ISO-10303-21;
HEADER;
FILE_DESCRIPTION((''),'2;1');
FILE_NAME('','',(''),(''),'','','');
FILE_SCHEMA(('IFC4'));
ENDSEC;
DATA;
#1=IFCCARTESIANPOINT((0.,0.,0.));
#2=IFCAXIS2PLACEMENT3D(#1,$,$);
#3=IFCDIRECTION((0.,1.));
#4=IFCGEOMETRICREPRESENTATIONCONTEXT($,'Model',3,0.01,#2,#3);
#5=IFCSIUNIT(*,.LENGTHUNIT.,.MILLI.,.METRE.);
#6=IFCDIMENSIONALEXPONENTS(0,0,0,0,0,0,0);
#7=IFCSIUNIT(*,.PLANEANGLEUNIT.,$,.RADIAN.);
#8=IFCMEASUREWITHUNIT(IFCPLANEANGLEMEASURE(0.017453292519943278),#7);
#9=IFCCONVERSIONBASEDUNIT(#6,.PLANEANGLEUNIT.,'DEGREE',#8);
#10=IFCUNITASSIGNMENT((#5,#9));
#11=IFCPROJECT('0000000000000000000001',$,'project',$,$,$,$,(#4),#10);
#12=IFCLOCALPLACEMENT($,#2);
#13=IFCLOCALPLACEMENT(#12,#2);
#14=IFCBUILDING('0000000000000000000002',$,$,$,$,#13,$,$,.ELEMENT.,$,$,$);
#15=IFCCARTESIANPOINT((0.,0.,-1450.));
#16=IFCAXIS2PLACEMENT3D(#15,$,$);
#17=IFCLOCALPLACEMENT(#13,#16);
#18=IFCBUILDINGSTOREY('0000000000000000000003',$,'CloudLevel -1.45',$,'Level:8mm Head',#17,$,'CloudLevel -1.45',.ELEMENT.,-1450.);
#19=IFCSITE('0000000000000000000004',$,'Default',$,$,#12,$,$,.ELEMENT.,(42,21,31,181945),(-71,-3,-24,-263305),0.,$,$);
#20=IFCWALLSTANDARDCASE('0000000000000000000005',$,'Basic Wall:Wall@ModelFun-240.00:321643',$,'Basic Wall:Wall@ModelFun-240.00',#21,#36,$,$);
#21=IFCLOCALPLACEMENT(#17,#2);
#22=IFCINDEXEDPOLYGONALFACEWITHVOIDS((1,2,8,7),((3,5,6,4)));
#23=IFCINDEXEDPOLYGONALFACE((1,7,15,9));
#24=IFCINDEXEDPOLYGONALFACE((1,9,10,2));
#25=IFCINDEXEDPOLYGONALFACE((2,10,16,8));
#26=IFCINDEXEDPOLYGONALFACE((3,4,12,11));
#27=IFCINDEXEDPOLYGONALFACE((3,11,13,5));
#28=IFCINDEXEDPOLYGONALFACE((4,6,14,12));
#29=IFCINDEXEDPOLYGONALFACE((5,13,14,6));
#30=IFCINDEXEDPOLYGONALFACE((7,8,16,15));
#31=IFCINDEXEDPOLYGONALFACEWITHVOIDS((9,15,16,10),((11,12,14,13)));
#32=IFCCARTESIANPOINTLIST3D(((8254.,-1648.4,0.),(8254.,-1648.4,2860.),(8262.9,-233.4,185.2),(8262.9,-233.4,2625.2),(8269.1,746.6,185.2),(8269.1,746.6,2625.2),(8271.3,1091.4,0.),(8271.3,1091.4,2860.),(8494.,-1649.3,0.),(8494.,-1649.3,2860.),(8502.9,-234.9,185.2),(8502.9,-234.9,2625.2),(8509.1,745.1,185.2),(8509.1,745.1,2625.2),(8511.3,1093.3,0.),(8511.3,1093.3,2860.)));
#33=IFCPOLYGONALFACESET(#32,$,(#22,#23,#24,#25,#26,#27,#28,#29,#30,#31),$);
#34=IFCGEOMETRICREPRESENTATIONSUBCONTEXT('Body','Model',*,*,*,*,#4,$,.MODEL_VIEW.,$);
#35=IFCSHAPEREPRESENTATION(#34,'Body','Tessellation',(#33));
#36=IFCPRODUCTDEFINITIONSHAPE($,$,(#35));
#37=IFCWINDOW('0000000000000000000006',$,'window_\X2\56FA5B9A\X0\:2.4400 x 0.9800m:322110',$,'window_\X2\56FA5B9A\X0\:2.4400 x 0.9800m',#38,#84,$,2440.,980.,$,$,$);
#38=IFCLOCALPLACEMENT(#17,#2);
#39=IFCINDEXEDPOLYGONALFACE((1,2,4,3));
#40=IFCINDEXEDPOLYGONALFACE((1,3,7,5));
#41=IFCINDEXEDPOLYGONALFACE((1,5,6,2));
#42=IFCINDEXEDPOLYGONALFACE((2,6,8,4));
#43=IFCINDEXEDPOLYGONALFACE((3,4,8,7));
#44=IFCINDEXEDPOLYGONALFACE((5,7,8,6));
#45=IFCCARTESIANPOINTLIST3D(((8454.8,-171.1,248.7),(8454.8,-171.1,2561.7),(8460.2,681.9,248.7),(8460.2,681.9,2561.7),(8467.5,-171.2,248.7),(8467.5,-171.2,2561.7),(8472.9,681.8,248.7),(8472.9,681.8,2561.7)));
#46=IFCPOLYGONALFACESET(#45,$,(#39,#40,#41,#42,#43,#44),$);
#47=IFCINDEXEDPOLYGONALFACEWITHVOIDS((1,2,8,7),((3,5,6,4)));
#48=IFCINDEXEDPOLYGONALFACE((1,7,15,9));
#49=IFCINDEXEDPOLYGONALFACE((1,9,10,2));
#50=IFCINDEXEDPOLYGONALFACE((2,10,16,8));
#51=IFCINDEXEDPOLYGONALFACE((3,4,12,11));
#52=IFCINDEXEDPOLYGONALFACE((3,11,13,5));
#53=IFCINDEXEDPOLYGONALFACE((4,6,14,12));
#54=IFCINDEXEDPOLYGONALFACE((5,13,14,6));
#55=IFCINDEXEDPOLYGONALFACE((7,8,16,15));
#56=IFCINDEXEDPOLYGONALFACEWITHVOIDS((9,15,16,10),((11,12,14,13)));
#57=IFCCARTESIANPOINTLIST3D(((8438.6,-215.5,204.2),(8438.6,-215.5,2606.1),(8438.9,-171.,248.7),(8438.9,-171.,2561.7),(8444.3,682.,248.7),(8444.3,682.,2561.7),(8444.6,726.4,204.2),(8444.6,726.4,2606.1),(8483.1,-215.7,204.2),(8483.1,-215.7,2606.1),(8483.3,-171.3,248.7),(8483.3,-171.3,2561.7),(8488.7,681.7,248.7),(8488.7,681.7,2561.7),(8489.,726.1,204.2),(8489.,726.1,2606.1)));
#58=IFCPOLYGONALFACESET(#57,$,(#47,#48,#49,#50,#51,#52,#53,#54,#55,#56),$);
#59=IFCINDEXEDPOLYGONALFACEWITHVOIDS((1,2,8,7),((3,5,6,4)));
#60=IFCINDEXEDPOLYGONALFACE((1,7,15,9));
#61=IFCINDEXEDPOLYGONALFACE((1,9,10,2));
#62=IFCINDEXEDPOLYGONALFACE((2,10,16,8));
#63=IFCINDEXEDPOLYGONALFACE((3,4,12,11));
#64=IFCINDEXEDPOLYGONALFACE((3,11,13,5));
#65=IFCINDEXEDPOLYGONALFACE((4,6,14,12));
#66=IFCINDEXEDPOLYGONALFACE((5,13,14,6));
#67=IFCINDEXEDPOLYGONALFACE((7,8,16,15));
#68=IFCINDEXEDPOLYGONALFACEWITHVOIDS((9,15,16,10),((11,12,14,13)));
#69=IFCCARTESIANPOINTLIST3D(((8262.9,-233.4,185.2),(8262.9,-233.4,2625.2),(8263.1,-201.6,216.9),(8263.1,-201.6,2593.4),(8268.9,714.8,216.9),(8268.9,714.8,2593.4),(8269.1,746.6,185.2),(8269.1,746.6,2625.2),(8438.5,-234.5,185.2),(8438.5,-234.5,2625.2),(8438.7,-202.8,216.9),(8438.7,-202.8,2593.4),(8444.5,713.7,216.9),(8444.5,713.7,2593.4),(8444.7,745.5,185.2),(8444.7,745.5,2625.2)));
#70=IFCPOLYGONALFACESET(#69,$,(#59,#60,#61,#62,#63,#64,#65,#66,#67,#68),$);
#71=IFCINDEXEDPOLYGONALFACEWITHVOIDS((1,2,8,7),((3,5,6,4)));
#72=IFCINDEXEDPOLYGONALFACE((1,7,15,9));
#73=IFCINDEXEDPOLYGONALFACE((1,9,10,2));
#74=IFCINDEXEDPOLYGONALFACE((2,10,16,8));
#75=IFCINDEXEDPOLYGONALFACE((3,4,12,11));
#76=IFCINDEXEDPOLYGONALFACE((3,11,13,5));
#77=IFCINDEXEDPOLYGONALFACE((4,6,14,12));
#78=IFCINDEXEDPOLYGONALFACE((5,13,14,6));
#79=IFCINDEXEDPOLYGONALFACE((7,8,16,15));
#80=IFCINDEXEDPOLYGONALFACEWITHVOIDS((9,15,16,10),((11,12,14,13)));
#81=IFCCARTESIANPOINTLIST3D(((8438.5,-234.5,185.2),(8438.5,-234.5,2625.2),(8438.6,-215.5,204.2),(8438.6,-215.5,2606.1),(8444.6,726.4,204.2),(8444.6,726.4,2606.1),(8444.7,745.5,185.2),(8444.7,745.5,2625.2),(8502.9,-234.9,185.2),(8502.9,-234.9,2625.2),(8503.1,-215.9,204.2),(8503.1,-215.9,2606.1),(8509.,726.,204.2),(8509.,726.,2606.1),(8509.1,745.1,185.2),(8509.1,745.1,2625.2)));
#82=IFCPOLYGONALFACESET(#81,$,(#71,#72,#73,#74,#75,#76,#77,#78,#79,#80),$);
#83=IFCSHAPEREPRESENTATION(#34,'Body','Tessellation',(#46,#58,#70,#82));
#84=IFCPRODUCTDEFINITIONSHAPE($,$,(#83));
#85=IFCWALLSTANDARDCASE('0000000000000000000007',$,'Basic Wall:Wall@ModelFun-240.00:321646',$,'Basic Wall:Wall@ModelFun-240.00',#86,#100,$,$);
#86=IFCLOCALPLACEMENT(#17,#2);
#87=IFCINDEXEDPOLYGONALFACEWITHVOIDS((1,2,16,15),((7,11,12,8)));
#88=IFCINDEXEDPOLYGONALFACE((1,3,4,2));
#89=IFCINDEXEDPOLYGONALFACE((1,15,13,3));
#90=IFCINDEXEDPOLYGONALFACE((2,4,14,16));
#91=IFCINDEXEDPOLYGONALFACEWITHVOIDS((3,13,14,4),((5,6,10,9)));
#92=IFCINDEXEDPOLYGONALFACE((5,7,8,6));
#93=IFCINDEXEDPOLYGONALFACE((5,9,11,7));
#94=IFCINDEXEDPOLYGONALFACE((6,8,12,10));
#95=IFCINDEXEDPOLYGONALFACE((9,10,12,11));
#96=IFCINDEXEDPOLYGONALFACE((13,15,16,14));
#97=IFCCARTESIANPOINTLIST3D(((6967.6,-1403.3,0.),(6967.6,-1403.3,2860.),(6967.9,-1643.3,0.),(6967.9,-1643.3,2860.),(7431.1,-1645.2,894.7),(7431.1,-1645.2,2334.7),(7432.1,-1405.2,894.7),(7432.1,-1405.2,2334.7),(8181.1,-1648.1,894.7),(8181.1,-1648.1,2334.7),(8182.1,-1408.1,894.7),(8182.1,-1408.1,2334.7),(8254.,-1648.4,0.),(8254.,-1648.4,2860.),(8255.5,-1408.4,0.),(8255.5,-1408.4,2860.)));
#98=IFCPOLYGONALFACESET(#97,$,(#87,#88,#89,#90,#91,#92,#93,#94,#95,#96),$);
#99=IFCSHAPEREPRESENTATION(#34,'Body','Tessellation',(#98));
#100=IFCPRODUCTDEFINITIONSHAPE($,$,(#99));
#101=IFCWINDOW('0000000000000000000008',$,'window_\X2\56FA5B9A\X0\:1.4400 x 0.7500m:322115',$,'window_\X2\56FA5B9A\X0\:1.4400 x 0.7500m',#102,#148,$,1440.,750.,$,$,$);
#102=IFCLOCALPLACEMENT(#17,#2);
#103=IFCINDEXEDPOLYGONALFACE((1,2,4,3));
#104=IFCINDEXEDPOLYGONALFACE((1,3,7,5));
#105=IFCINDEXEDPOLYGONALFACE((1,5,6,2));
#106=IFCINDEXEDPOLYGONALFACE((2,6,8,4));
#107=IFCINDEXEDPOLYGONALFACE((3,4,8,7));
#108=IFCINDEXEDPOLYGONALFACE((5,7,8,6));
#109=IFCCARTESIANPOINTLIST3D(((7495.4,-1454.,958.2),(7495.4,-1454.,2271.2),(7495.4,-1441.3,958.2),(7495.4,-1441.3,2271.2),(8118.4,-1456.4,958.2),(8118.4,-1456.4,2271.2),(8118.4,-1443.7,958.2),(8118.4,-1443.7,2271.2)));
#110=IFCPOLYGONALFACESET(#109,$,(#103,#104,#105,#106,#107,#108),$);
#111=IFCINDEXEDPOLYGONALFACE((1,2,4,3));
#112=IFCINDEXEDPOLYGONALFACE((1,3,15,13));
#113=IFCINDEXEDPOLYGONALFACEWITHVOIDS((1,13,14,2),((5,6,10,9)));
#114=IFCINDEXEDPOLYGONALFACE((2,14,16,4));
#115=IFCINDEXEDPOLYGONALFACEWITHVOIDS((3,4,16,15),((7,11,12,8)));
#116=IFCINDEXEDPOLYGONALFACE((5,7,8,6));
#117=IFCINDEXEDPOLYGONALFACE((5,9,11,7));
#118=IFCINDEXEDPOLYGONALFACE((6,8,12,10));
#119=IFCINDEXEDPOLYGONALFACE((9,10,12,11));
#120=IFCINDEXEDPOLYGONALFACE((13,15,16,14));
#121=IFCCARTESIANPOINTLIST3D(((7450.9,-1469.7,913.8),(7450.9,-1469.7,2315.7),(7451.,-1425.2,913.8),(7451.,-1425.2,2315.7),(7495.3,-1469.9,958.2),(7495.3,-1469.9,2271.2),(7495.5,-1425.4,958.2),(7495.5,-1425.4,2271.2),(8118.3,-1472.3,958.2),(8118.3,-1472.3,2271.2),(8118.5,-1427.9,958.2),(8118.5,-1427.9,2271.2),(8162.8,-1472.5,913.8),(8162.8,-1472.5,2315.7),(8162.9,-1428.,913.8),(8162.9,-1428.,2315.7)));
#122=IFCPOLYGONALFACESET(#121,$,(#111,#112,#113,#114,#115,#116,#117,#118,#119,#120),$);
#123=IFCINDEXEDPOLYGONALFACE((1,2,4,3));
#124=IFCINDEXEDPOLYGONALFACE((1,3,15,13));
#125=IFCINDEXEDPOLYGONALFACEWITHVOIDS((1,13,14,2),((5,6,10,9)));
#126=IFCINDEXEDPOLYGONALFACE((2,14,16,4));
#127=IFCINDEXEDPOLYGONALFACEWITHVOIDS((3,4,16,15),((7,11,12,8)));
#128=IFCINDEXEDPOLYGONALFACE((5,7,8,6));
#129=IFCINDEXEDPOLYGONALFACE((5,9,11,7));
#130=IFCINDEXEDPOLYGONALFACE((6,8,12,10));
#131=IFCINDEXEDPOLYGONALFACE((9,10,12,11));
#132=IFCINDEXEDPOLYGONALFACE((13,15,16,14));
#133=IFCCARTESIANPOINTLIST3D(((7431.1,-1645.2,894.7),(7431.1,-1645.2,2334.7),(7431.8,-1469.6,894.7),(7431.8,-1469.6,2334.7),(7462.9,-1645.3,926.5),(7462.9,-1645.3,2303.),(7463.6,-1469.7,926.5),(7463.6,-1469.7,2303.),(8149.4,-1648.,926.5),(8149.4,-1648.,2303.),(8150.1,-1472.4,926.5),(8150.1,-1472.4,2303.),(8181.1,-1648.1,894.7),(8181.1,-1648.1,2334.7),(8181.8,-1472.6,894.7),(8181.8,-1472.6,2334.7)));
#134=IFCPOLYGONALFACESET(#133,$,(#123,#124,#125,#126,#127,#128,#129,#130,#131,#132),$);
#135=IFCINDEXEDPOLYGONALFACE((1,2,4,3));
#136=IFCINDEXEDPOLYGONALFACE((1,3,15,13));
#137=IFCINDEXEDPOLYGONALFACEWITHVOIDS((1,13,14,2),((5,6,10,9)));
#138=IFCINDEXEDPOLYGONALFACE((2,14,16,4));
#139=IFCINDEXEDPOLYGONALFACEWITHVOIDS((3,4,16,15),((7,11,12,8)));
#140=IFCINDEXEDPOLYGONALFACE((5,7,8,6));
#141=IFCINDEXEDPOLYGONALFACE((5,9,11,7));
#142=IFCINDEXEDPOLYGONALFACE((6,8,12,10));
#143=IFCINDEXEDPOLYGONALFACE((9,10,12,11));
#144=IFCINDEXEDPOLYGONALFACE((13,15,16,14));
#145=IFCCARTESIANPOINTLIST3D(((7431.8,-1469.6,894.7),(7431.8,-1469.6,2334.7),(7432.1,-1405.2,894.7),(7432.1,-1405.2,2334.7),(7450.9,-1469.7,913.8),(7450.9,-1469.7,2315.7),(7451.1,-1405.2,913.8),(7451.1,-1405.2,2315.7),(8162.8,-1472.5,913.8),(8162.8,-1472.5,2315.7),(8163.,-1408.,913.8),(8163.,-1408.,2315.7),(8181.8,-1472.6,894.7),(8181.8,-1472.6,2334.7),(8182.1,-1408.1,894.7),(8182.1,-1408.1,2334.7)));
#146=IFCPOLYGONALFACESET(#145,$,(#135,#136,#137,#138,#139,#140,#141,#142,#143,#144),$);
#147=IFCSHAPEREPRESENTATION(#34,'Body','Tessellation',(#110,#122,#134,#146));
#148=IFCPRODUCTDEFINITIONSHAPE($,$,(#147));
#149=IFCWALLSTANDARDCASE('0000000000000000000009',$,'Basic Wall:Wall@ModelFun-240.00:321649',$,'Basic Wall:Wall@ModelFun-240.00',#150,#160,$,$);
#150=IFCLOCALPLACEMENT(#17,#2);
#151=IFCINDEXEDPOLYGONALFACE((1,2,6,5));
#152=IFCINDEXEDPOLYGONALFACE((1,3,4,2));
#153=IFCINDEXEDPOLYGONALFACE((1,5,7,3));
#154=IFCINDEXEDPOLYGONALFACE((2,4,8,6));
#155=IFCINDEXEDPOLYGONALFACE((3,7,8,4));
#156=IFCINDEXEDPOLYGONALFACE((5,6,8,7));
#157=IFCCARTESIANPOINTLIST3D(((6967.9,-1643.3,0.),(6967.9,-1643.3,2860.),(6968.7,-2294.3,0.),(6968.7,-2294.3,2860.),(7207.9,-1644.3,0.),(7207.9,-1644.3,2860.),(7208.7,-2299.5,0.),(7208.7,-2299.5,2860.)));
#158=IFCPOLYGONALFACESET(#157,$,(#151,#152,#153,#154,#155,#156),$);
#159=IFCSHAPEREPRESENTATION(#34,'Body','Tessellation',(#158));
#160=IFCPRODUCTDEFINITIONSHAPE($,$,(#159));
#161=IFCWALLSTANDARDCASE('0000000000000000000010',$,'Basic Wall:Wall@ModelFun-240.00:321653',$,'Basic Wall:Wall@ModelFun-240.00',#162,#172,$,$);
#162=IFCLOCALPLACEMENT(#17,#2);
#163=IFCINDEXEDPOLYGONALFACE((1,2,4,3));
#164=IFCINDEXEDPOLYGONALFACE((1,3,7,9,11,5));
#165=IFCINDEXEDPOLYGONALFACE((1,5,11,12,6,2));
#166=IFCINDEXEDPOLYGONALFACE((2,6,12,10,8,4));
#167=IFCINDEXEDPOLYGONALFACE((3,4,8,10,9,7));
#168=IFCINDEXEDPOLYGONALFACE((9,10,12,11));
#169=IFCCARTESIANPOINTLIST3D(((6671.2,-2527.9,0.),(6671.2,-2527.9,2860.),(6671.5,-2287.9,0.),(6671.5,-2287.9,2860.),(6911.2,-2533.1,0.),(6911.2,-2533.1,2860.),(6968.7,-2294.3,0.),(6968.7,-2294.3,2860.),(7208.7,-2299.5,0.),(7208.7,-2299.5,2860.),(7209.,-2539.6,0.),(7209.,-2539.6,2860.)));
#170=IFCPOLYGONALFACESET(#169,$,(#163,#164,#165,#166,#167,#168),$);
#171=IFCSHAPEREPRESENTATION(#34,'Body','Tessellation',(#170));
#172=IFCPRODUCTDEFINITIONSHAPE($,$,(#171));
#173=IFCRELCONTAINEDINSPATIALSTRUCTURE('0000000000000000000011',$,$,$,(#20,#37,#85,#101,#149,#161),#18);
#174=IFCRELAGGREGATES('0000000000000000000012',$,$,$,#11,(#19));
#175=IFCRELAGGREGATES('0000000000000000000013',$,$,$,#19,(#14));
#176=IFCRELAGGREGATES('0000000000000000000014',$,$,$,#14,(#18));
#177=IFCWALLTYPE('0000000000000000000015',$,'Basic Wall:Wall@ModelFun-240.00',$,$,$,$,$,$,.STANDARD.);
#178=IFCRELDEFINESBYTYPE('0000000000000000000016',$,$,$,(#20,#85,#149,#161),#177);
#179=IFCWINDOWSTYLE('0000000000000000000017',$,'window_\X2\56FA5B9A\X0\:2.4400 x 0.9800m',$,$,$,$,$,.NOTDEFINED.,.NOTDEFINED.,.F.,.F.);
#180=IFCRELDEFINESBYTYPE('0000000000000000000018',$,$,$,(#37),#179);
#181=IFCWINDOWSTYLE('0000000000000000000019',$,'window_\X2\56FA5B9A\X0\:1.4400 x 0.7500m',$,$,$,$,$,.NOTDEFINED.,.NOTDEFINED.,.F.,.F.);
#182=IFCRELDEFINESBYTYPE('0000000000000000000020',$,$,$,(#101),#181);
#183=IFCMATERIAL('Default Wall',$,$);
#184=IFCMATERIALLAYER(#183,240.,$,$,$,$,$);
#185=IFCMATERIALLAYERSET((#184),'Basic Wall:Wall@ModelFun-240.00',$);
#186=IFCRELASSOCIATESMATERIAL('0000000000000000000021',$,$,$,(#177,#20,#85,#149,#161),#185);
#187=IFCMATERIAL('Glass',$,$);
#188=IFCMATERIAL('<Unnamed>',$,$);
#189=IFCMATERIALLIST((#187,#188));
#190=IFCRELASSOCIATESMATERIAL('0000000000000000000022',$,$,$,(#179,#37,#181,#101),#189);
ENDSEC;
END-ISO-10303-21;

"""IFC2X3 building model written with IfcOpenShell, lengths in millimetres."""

from ifc_helpers import new_model, entity, si_unit, converted_unit, direction, frame, frame_2d, origin, place, context, subcontext, project, spatial, polyline, rectangle, outline, extrude, source, transform, mapped, material, material_list, layer, layer_set, layer_usage, type_object, type_shapes, element, fill, save


model = new_model("IFC2X3")

# Units and contexts
model_context = context("Model", 3, precision=0.01, world=origin(), true_north=direction((0.0, 1.0)))
body_context = subcontext(model_context, "Body", "Model", "MODEL_VIEW")
ifc_project = project(units=[si_unit("LENGTHUNIT", "METRE", prefix="MILLI"), converted_unit("PLANEANGLEUNIT", "DEGREE", entity("IfcPlaneAngleMeasure", 0.017453292519943278), si_unit("PLANEANGLEUNIT", "RADIAN"), dimensions=[0, 0, 0, 0, 0, 0, 0])], contexts=[model_context])

# Site, building, storey
site_placement = place(None, origin())
site = spatial("IfcSite", under=ifc_project, at=site_placement, Name="Default", CompositionType="ELEMENT", RefLatitude=(42, 21, 31, 181945), RefLongitude=(-71, -3, -24, -263305), RefElevation=0.0)
building_placement = place(site_placement, origin())
building = spatial("IfcBuilding", under=site, at=building_placement, CompositionType="ELEMENT")
storey_placement = place(building_placement, frame((0.0, 0.0, -1450.0)))
storey = spatial("IfcBuildingStorey", under=building, at=storey_placement, Name="CloudLevel -1.45", ObjectType="Level:8mm Head", LongName="CloudLevel -1.45", CompositionType="ELEMENT", Elevation=-1450.0)

# Walls, openings, windows
ifc_material_1 = material(Name="Default Wall")
ifc_layer_1 = layer(ifc_material_1, 240.0)
ifc_layer_set_1 = layer_set([ifc_layer_1], Name="Basic Wall:Wall@ModelFun-240.00")
ifc_layer_usage_1 = layer_usage(ifc_layer_set_1, "AXIS2", "NEGATIVE", 120.0)
wall_type_1 = type_object("IfcWallType", Name="Basic Wall:Wall@ModelFun-240.00", PredefinedType="STANDARD", material=ifc_layer_set_1)
wall_1_placement = place(storey_placement, frame((8374.0, -1649.1, 0.0), z_axis=(0.0, 0.0, 1.0), x_axis=(0.006325, 0.99998, 0.0)))
wall_1 = element("IfcWallStandardCase", 1, at=wall_1_placement, inside=storey, type_object=wall_type_1, material=ifc_layer_usage_1, Name="Basic Wall:Wall@ModelFun-240.00:321643", ObjectType="Basic Wall:Wall@ModelFun-240.00", context=body_context, shape_type="SweptSolid", body=[
    extrude(outline(polyline([(2743.3, -120.0), (2739.9, 120.0), (240.0, 120.0), (0.0, 120.0), (0.3, -16.2), (0.6, -120.0), (240.6, -120.0), (2743.3, -120.0)])), origin(), (0.0, 0.0, 1.0), 2860.0),
])
opening_1_placement = place(wall_1_placement, frame((2395.0, 120.0, 185.2)))
opening_1 = element("IfcOpeningElement", 2, at=opening_1_placement, cuts=wall_1, ObjectType="Opening", context=body_context, shape_type="SweptSolid", body=[
    extrude(rectangle(XDim=2440.0, YDim=980.0, at=frame_2d((1220.0, 490.0), x_axis=(-1.0, 0.0))), frame((0.0, 0.0, 0.0), z_axis=(0.0, -1.0, 0.0), x_axis=(0.0, 0.0, 1.0)), (0.0, 0.0, 1.0), 240.0),
])
ifc_material_2 = material(Name="Glass")
ifc_material_3 = material(Name="<Unnamed>")
ifc_material_list = material_list([ifc_material_2, ifc_material_3])
window_style_1 = type_object("IfcWindowStyle", Name="window_固定:2.4400 x 0.9800m", ConstructionType="NOTDEFINED", OperationType="NOTDEFINED", ParameterTakesPrecedence=False, Sizeable=False, material=ifc_material_list)
shared_shape_1 = source(origin(), body_context, "Body", "SweptSolid", [
    extrude(rectangle(XDim=853.0, YDim=12.7, at=frame_2d((0.0, 0.0), x_axis=(1.0, 0.0))), frame((566.2, 197.8, 63.5)), (0.0, 0.0, 1.0), 2313.0),
    extrude(outline(polyline([(-470.9, -1200.9), (470.9, -1200.9), (470.9, 1200.9), (-470.9, 1200.9), (-470.9, -1200.9)]), holes=[polyline([(-426.5, -1156.5), (-426.5, 1156.5), (426.5, 1156.5), (426.5, -1156.5), (-426.5, -1156.5)])]), frame((566.2, 220.0, 1220.0), z_axis=(0.0, -1.0, 0.0), x_axis=(-1.0, 0.0, 0.0)), (0.0, 0.0, 1.0), 44.4),
    extrude(outline(polyline([(-490.0, -1220.0), (490.0, -1220.0), (490.0, 1220.0), (-490.0, 1220.0), (-490.0, -1220.0)]), holes=[polyline([(-458.2, -1188.2), (-458.2, 1188.2), (458.2, 1188.2), (458.2, -1188.2), (-458.2, -1188.2)])]), frame((566.2, 175.5, 1220.0), z_axis=(0.0, -1.0, 0.0), x_axis=(-1.0, 0.0, 0.0)), (0.0, 0.0, 1.0), 175.5),
    extrude(outline(polyline([(-1220.0, -490.0), (1220.0, -490.0), (1220.0, 490.0), (-1220.0, 490.0), (-1220.0, -490.0)]), holes=[polyline([(-1200.9, -470.9), (-1200.9, 470.9), (1200.9, 470.9), (1200.9, -470.9), (-1200.9, -470.9)])]), frame((566.2, 240.0, 1220.0), z_axis=(0.0, -1.0, 0.0), x_axis=(0.0, 0.0, -1.0)), (0.0, 0.0, 1.0), 64.4),
])
type_shapes(window_style_1, [shared_shape_1])
window_1_placement = place(opening_1_placement, frame((76.2, 0.0, 0.0), z_axis=(0.0, 0.0, 1.0), x_axis=(-1.0, 0.0, 0.0)))
window_1 = element("IfcWindow", 3, at=window_1_placement, inside=storey, type_object=window_style_1, material=ifc_material_list, Name="window_固定:2.4400 x 0.9800m:322110", ObjectType="window_固定:2.4400 x 0.9800m", OverallHeight=2440.0, OverallWidth=980.0, context=body_context, shape_type="MappedRepresentation", body=[
    mapped(shared_shape_1, transform((0.0, 0.0, 0.0), scale=1.0)),
])
fill(opening_1, window_1)
wall_2_placement = place(storey_placement, frame((8255.0, -1528.4, 0.0), z_axis=(0.0, 0.0, 1.0), x_axis=(-0.999992, 0.003928, 0.0)))
wall_2 = element("IfcWallStandardCase", 4, at=wall_2_placement, inside=storey, type_object=wall_type_1, material=ifc_layer_usage_1, Name="Basic Wall:Wall@ModelFun-240.00:321646", ObjectType="Basic Wall:Wall@ModelFun-240.00", context=body_context, shape_type="SweptSolid", body=[
    extrude(outline(polyline([(1287.9, -120.0), (1287.7, -82.7), (1286.7, 117.3), (1286.7, 120.0), (1046.7, 120.0), (0.6, 120.0), (0.0, -120.0), (988.3, -120.0), (1198.3, -120.0), (1287.9, -120.0)])), origin(), (0.0, 0.0, 1.0), 2860.0),
])
opening_2_placement = place(wall_2_placement, frame((823.4, 120.0, 894.7)))
opening_2 = element("IfcOpeningElement", 5, at=opening_2_placement, cuts=wall_2, ObjectType="Opening", context=body_context, shape_type="SweptSolid", body=[
    extrude(rectangle(XDim=1440.0, YDim=750.0, at=frame_2d((720.0, 375.0), x_axis=(-1.0, 0.0))), frame((0.0, 0.0, 0.0), z_axis=(0.0, -1.0, 0.0), x_axis=(0.0, 0.0, 1.0)), (0.0, 0.0, 1.0), 240.0),
])
window_style_2 = type_object("IfcWindowStyle", Name="window_固定:1.4400 x 0.7500m", ConstructionType="NOTDEFINED", OperationType="NOTDEFINED", ParameterTakesPrecedence=False, Sizeable=False, material=ifc_material_list)
shared_shape_2 = source(origin(), body_context, "Body", "SweptSolid", [
    extrude(rectangle(XDim=623.0, YDim=12.7, at=frame_2d((0.0, 0.0), x_axis=(1.0, 0.0))), frame((451.2, 197.8, 63.5)), (0.0, 0.0, 1.0), 1313.0),
    extrude(outline(polyline([(-355.9, -700.9), (355.9, -700.9), (355.9, 700.9), (-355.9, 700.9), (-355.9, -700.9)]), holes=[polyline([(-311.5, -656.5), (-311.5, 656.5), (311.5, 656.5), (311.5, -656.5), (-311.5, -656.5)])]), frame((451.2, 220.0, 720.0), z_axis=(0.0, -1.0, 0.0), x_axis=(-1.0, 0.0, 0.0)), (0.0, 0.0, 1.0), 44.4),
    extrude(outline(polyline([(-375.0, -720.0), (375.0, -720.0), (375.0, 720.0), (-375.0, 720.0), (-375.0, -720.0)]), holes=[polyline([(-343.2, -688.2), (-343.2, 688.2), (343.2, 688.2), (343.2, -688.2), (-343.2, -688.2)])]), frame((451.2, 175.5, 720.0), z_axis=(0.0, -1.0, 0.0), x_axis=(-1.0, 0.0, 0.0)), (0.0, 0.0, 1.0), 175.5),
    extrude(outline(polyline([(-720.0, -375.0), (720.0, -375.0), (720.0, 375.0), (-720.0, 375.0), (-720.0, -375.0)]), holes=[polyline([(-700.9, -355.9), (-700.9, 355.9), (700.9, 355.9), (700.9, -355.9), (-700.9, -355.9)])]), frame((451.2, 240.0, 720.0), z_axis=(0.0, -1.0, 0.0), x_axis=(0.0, 0.0, -1.0)), (0.0, 0.0, 1.0), 64.4),
])
type_shapes(window_style_2, [shared_shape_2])
window_2_placement = place(opening_2_placement, frame((76.2, 0.0, 0.0), z_axis=(0.0, 0.0, 1.0), x_axis=(-1.0, 0.0, 0.0)))
window_2 = element("IfcWindow", 6, at=window_2_placement, inside=storey, type_object=window_style_2, material=ifc_material_list, Name="window_固定:1.4400 x 0.7500m:322115", ObjectType="window_固定:1.4400 x 0.7500m", OverallHeight=1440.0, OverallWidth=750.0, context=body_context, shape_type="MappedRepresentation", body=[
    mapped(shared_shape_2, transform((0.0, 0.0, 0.0), scale=1.0)),
])
fill(opening_2, window_2)

# Walls
wall_3_placement = place(storey_placement, frame((7087.9, -1643.2, 0.0), z_axis=(0.0, 0.0, 1.0), x_axis=(0.001211, -0.999999, 0.0)))
element("IfcWallStandardCase", 7, at=wall_3_placement, inside=storey, type_object=wall_type_1, material=ifc_layer_usage_1, Name="Basic Wall:Wall@ModelFun-240.00:321649", ObjectType="Basic Wall:Wall@ModelFun-240.00", context=body_context, shape_type="SweptSolid", body=[
    extrude(outline(polyline([(651.0, -120.0), (656.5, 120.0), (1.2, 120.0), (0.0, -120.0), (651.0, -120.0)])), origin(), (0.0, 0.0, 1.0), 2860.0),
])
wall_4_placement = place(storey_placement, frame((7211.6, -2419.6, 0.0), z_axis=(0.0, 0.0, 1.0), x_axis=(-0.999764, 0.021716, 0.0)))
element("IfcWallStandardCase", 8, at=wall_4_placement, inside=storey, type_object=wall_type_1, material=ifc_layer_usage_1, Name="Basic Wall:Wall@ModelFun-240.00:321653", ObjectType="Basic Wall:Wall@ModelFun-240.00", context=body_context, shape_type="SweptSolid", body=[
    extrude(outline(polyline([(542.8, -120.0), (537.9, 120.0), (297.8, 120.0), (0.0, 120.0), (5.5, -120.0), (245.6, -120.0), (542.8, -120.0)])), origin(), (0.0, 0.0, 1.0), 2860.0),
])

save(model, "model.ifc")
